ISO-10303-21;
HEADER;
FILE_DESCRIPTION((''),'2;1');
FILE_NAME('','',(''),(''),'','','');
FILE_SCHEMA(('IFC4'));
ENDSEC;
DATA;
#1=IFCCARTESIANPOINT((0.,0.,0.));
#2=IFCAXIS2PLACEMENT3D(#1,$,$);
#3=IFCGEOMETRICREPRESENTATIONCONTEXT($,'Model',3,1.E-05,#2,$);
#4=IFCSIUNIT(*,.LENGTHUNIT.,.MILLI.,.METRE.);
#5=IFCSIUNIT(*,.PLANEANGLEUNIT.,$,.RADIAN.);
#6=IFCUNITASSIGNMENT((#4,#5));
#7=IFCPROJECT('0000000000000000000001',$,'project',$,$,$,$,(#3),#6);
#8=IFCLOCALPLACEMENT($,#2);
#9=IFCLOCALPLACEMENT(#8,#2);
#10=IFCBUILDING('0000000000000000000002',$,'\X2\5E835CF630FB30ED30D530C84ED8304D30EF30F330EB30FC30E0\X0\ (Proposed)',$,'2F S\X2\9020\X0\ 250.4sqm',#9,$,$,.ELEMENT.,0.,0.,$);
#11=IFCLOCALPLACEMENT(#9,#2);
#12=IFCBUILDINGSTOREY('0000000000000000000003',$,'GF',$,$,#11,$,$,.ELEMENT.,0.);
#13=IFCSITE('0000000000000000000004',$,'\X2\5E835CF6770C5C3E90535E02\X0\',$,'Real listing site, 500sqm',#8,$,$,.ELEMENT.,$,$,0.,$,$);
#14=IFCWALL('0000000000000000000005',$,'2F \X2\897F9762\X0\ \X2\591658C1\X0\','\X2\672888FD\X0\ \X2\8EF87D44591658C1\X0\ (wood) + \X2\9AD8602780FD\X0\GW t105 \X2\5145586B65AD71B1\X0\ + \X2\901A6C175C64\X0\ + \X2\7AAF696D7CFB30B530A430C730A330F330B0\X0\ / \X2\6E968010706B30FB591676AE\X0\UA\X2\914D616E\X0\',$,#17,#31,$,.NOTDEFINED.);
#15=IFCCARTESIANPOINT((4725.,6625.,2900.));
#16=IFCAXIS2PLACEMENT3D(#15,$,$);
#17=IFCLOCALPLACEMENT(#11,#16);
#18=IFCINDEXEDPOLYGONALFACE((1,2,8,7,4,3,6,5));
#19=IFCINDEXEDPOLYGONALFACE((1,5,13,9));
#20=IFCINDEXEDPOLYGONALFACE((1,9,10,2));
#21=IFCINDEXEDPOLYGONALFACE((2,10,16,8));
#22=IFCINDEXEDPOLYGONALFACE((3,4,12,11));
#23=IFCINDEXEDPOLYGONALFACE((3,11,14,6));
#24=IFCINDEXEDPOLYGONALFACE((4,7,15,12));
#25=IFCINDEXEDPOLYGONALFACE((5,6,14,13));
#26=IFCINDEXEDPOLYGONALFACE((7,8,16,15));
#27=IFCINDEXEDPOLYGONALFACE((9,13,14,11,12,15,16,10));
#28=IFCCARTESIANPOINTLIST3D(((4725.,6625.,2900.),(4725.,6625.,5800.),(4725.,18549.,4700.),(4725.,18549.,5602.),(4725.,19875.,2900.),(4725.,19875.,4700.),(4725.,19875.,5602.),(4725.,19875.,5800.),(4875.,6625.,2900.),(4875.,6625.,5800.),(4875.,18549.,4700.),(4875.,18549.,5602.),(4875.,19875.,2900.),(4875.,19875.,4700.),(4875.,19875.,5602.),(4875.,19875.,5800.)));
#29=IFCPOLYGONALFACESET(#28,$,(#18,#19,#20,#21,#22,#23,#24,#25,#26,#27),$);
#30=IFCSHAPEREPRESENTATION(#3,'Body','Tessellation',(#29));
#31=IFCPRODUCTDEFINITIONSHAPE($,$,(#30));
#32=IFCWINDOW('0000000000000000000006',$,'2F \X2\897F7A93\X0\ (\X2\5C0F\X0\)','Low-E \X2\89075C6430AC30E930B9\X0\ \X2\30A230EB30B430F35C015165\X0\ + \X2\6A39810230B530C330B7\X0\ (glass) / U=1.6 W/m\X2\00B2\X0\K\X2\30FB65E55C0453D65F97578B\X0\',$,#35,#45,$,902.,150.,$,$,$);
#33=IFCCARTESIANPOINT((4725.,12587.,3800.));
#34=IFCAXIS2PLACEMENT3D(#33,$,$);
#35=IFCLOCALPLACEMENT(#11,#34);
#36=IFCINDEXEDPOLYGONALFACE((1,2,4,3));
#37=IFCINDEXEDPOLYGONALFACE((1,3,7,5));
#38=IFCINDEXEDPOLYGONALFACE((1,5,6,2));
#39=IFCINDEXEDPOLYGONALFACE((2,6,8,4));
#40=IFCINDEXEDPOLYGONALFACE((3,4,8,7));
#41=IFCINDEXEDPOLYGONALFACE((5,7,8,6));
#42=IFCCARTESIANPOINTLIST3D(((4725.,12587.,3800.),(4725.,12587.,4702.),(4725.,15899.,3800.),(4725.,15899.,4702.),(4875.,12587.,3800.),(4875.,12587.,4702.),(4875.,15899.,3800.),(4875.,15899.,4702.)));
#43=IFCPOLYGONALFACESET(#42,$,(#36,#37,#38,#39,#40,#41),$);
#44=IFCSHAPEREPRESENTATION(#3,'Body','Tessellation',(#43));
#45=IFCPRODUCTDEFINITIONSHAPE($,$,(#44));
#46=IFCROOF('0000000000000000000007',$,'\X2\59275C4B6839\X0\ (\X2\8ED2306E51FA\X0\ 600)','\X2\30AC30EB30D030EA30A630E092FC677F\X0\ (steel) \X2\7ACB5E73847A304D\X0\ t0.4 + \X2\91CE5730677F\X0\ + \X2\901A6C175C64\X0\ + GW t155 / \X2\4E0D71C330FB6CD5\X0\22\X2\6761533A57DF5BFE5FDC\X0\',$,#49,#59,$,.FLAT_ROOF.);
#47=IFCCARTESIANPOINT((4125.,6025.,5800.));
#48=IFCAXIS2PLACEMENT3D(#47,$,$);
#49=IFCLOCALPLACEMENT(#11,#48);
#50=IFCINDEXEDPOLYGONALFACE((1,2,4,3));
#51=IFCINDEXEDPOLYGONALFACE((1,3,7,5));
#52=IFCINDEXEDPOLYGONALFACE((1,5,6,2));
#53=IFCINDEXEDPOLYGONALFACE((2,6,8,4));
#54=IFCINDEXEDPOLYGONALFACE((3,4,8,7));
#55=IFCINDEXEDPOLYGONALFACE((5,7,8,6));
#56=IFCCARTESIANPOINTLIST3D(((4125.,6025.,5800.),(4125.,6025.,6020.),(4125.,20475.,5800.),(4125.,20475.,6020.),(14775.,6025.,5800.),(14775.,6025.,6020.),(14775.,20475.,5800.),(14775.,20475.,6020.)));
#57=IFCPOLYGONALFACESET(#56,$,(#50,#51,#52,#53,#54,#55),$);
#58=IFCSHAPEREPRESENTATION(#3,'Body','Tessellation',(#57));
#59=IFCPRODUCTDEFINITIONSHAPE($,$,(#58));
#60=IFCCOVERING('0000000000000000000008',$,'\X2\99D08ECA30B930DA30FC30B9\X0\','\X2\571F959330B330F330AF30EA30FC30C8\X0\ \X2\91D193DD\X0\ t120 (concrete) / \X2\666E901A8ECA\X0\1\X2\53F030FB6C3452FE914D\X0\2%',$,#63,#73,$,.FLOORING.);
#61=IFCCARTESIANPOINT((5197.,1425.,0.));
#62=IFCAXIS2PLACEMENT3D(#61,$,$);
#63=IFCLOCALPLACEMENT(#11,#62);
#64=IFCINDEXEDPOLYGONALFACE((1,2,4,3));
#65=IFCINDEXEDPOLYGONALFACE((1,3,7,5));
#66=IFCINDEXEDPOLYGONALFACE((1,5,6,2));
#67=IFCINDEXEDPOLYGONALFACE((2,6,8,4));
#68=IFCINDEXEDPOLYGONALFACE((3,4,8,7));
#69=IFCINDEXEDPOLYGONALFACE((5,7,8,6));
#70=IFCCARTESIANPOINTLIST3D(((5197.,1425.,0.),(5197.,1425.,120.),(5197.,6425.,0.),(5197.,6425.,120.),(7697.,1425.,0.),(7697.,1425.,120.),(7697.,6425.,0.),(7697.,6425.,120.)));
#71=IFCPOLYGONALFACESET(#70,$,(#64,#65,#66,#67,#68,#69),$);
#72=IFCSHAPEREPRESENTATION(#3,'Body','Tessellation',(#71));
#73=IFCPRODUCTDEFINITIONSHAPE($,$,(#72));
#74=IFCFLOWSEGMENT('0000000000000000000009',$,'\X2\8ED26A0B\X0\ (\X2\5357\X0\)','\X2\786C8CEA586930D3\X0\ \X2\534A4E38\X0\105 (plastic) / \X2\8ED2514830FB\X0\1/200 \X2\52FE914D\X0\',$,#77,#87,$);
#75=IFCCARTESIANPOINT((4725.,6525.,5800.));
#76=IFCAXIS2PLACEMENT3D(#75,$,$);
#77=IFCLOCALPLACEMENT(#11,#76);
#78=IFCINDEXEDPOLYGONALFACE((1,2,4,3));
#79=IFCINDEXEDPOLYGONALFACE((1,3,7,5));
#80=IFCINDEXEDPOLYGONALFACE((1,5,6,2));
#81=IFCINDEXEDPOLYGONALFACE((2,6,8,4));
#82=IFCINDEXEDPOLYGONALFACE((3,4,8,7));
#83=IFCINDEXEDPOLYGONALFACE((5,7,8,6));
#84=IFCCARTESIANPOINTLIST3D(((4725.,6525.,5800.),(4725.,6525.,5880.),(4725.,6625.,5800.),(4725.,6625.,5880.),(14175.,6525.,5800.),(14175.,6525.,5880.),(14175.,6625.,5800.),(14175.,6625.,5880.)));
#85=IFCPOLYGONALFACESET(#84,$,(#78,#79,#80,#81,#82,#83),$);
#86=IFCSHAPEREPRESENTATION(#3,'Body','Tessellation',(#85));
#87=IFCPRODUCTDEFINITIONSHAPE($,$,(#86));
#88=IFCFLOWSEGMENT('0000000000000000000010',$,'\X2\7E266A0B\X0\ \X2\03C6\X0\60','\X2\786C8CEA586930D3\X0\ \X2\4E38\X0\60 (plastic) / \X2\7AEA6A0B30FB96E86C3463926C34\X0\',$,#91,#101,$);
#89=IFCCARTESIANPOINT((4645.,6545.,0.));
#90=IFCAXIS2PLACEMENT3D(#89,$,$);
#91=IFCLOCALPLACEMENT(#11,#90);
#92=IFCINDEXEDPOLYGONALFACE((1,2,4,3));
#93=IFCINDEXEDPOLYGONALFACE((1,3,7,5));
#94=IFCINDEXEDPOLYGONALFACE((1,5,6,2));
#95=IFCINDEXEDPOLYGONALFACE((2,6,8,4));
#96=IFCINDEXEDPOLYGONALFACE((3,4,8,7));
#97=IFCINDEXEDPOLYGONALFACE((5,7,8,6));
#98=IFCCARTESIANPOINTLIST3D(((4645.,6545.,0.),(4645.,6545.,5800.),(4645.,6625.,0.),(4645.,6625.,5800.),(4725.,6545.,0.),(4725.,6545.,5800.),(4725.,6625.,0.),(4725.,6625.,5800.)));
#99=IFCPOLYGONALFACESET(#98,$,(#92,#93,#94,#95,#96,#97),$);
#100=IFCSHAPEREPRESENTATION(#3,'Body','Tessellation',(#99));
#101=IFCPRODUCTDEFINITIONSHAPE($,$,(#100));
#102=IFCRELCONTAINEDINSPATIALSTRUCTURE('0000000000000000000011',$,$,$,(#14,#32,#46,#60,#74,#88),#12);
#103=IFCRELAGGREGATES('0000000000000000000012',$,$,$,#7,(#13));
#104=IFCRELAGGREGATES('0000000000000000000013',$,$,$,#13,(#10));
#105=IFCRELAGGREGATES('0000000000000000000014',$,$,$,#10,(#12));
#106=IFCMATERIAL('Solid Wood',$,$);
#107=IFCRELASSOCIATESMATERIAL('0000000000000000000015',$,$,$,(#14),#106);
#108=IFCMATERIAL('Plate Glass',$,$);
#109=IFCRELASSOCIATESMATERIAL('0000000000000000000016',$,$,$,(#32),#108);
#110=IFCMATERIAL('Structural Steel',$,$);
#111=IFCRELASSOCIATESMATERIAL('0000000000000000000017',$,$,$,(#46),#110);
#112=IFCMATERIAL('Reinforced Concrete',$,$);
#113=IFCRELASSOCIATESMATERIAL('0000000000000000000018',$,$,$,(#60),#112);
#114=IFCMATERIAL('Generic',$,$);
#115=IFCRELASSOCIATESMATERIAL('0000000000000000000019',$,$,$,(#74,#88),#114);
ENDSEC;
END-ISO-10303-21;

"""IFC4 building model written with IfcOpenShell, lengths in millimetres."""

from ifc_helpers import new_model, si_unit, frame, frame_2d, origin, place, context, project, spatial, rectangle, extrude, material, element, fill, save


model = new_model("IFC4")

# Units and contexts
model_context = context("Model", 3, precision=1e-05, world=origin())
ifc_project = project(units=[si_unit("LENGTHUNIT", "METRE", prefix="MILLI"), si_unit("PLANEANGLEUNIT", "RADIAN")], contexts=[model_context])

# Site, building, storey
site_placement = place(None, origin())
site = spatial("IfcSite", under=ifc_project, at=site_placement, Name="広島県尾道市", ObjectType="Real listing site, 500sqm", CompositionType="ELEMENT", RefElevation=0.0)
building_placement = place(site_placement, origin())
building = spatial("IfcBuilding", under=site, at=building_placement, Name="広島・ロフト付きワンルーム (Proposed)", ObjectType="2F S造 250.4sqm", CompositionType="ELEMENT", ElevationOfRefHeight=0.0, ElevationOfTerrain=0.0)
storey_placement = place(building_placement, origin())
storey = spatial("IfcBuildingStorey", under=building, at=storey_placement, Name="GF", CompositionType="ELEMENT", Elevation=0.0)

# Shared definitions
ifc_material_1 = material(Name="Solid Wood")

# Shared definitions
ifc_material_2 = material(Name="Reinforced Concrete")

# Shared definitions
ifc_material_3 = material(Name="Plate Glass")

# Wall, opening, window
wall_1_placement = place(storey_placement, frame((4725.0, 6625.0, 2900.0)))
wall_1 = element("IfcWall", 1, at=wall_1_placement, inside=storey, material=ifc_material_1, Name="2F 西面 外壁", Description="木製 軸組外壁 (wood) + 高性能GW t105 充填断熱 + 通気層 + 窯業系サイディング / 準耐火・外皮UA配慮", PredefinedType="NOTDEFINED", context=model_context, shape_type="SweptSolid", body=[
    extrude(rectangle(XDim=150.0, YDim=13250.0, at=frame_2d((75.0, 6625.0))), frame((4725.0, 6625.0, 2900.0)), (0.0, 0.0, 1.0), 2900.0),
])
opening_1_placement = place(storey_placement, frame((4725.0, 12587.0, 3800.0)))
opening_1 = element("IfcOpeningElement", 2, at=opening_1_placement, cuts=wall_1, PredefinedType="NOTDEFINED", context=model_context, shape_type="SweptSolid", body=[
    extrude(rectangle(XDim=150.0, YDim=3312.0, at=frame_2d((75.0, 1656.0))), frame((4725.0, 12587.0, 3800.0)), (0.0, 0.0, 1.0), 902.0),
])
window_1_placement = place(storey_placement, frame((4725.0, 12587.0, 3800.0)))
window_1 = element("IfcWindow", 3, at=window_1_placement, inside=storey, material=ifc_material_3, Name="2F 西窓 (小)", Description="Low-E 複層ガラス アルゴン封入 + 樹脂サッシ (glass) / U=1.6 W/m²K・日射取得型", OverallHeight=902.0, OverallWidth=150.0, context=model_context, shape_type="SweptSolid", body=[
    extrude(rectangle(XDim=150.0, YDim=3312.0, at=frame_2d((75.0, 1656.0))), frame((4725.0, 12587.0, 3800.0)), (0.0, 0.0, 1.0), 902.0),
])
fill(opening_1, window_1)

# Roof
ifc_material_4 = material(Name="Structural Steel")
roof_placement = place(storey_placement, frame((4125.0, 6025.0, 5800.0)))
element("IfcRoof", 4, at=roof_placement, inside=storey, material=ifc_material_4, Name="大屋根 (軒の出 600)", Description="ガルバリウム鋼板 (steel) 立平葺き t0.4 + 野地板 + 通気層 + GW t155 / 不燃・法22条区域対応", PredefinedType="FLAT_ROOF", context=model_context, shape_type="SweptSolid", body=[
    extrude(rectangle(XDim=10650.0, YDim=14450.0, at=frame_2d((5325.0, 7225.0))), frame((4125.0, 6025.0, 5800.0)), (0.0, 0.0, 1.0), 220.0),
])

# Covering
covering_placement = place(storey_placement, frame((5197.0, 1425.0, 0.0)))
element("IfcCovering", 5, at=covering_placement, inside=storey, material=ifc_material_2, Name="駐車スペース", Description="土間コンクリート 金鏝 t120 (concrete) / 普通車1台・水勾配2%", PredefinedType="FLOORING", context=model_context, shape_type="SweptSolid", body=[
    extrude(rectangle(XDim=2500.0, YDim=5000.0, at=frame_2d((1250.0, 2500.0))), frame((5197.0, 1425.0, 0.0)), (0.0, 0.0, 1.0), 120.0),
])

# Flow segments
ifc_material_5 = material(Name="Generic")
flow_segment_1_placement = place(storey_placement, frame((4725.0, 6525.0, 5800.0)))
element("IfcFlowSegment", 6, at=flow_segment_1_placement, inside=storey, material=ifc_material_5, Name="軒樋 (南)", Description="硬質塩ビ 半丸105 (plastic) / 軒先・1/200 勾配", context=model_context, shape_type="SweptSolid", body=[
    extrude(rectangle(XDim=9450.0, YDim=100.0, at=frame_2d((4725.0, 50.0))), frame((4725.0, 6525.0, 5800.0)), (0.0, 0.0, 1.0), 80.0),
])
flow_segment_2_placement = place(storey_placement, frame((4645.0, 6545.0, 0.0)))
element("IfcFlowSegment", 7, at=flow_segment_2_placement, inside=storey, material=ifc_material_5, Name="縦樋 φ60", Description="硬質塩ビ 丸60 (plastic) / 竪樋・雨水排水", context=model_context, shape_type="SweptSolid", body=[
    extrude(rectangle(XDim=80.0, YDim=80.0, at=frame_2d((40.0, 40.0))), frame((4645.0, 6545.0, 0.0)), (0.0, 0.0, 1.0), 5800.0),
])

save(model, "model.ifc")
